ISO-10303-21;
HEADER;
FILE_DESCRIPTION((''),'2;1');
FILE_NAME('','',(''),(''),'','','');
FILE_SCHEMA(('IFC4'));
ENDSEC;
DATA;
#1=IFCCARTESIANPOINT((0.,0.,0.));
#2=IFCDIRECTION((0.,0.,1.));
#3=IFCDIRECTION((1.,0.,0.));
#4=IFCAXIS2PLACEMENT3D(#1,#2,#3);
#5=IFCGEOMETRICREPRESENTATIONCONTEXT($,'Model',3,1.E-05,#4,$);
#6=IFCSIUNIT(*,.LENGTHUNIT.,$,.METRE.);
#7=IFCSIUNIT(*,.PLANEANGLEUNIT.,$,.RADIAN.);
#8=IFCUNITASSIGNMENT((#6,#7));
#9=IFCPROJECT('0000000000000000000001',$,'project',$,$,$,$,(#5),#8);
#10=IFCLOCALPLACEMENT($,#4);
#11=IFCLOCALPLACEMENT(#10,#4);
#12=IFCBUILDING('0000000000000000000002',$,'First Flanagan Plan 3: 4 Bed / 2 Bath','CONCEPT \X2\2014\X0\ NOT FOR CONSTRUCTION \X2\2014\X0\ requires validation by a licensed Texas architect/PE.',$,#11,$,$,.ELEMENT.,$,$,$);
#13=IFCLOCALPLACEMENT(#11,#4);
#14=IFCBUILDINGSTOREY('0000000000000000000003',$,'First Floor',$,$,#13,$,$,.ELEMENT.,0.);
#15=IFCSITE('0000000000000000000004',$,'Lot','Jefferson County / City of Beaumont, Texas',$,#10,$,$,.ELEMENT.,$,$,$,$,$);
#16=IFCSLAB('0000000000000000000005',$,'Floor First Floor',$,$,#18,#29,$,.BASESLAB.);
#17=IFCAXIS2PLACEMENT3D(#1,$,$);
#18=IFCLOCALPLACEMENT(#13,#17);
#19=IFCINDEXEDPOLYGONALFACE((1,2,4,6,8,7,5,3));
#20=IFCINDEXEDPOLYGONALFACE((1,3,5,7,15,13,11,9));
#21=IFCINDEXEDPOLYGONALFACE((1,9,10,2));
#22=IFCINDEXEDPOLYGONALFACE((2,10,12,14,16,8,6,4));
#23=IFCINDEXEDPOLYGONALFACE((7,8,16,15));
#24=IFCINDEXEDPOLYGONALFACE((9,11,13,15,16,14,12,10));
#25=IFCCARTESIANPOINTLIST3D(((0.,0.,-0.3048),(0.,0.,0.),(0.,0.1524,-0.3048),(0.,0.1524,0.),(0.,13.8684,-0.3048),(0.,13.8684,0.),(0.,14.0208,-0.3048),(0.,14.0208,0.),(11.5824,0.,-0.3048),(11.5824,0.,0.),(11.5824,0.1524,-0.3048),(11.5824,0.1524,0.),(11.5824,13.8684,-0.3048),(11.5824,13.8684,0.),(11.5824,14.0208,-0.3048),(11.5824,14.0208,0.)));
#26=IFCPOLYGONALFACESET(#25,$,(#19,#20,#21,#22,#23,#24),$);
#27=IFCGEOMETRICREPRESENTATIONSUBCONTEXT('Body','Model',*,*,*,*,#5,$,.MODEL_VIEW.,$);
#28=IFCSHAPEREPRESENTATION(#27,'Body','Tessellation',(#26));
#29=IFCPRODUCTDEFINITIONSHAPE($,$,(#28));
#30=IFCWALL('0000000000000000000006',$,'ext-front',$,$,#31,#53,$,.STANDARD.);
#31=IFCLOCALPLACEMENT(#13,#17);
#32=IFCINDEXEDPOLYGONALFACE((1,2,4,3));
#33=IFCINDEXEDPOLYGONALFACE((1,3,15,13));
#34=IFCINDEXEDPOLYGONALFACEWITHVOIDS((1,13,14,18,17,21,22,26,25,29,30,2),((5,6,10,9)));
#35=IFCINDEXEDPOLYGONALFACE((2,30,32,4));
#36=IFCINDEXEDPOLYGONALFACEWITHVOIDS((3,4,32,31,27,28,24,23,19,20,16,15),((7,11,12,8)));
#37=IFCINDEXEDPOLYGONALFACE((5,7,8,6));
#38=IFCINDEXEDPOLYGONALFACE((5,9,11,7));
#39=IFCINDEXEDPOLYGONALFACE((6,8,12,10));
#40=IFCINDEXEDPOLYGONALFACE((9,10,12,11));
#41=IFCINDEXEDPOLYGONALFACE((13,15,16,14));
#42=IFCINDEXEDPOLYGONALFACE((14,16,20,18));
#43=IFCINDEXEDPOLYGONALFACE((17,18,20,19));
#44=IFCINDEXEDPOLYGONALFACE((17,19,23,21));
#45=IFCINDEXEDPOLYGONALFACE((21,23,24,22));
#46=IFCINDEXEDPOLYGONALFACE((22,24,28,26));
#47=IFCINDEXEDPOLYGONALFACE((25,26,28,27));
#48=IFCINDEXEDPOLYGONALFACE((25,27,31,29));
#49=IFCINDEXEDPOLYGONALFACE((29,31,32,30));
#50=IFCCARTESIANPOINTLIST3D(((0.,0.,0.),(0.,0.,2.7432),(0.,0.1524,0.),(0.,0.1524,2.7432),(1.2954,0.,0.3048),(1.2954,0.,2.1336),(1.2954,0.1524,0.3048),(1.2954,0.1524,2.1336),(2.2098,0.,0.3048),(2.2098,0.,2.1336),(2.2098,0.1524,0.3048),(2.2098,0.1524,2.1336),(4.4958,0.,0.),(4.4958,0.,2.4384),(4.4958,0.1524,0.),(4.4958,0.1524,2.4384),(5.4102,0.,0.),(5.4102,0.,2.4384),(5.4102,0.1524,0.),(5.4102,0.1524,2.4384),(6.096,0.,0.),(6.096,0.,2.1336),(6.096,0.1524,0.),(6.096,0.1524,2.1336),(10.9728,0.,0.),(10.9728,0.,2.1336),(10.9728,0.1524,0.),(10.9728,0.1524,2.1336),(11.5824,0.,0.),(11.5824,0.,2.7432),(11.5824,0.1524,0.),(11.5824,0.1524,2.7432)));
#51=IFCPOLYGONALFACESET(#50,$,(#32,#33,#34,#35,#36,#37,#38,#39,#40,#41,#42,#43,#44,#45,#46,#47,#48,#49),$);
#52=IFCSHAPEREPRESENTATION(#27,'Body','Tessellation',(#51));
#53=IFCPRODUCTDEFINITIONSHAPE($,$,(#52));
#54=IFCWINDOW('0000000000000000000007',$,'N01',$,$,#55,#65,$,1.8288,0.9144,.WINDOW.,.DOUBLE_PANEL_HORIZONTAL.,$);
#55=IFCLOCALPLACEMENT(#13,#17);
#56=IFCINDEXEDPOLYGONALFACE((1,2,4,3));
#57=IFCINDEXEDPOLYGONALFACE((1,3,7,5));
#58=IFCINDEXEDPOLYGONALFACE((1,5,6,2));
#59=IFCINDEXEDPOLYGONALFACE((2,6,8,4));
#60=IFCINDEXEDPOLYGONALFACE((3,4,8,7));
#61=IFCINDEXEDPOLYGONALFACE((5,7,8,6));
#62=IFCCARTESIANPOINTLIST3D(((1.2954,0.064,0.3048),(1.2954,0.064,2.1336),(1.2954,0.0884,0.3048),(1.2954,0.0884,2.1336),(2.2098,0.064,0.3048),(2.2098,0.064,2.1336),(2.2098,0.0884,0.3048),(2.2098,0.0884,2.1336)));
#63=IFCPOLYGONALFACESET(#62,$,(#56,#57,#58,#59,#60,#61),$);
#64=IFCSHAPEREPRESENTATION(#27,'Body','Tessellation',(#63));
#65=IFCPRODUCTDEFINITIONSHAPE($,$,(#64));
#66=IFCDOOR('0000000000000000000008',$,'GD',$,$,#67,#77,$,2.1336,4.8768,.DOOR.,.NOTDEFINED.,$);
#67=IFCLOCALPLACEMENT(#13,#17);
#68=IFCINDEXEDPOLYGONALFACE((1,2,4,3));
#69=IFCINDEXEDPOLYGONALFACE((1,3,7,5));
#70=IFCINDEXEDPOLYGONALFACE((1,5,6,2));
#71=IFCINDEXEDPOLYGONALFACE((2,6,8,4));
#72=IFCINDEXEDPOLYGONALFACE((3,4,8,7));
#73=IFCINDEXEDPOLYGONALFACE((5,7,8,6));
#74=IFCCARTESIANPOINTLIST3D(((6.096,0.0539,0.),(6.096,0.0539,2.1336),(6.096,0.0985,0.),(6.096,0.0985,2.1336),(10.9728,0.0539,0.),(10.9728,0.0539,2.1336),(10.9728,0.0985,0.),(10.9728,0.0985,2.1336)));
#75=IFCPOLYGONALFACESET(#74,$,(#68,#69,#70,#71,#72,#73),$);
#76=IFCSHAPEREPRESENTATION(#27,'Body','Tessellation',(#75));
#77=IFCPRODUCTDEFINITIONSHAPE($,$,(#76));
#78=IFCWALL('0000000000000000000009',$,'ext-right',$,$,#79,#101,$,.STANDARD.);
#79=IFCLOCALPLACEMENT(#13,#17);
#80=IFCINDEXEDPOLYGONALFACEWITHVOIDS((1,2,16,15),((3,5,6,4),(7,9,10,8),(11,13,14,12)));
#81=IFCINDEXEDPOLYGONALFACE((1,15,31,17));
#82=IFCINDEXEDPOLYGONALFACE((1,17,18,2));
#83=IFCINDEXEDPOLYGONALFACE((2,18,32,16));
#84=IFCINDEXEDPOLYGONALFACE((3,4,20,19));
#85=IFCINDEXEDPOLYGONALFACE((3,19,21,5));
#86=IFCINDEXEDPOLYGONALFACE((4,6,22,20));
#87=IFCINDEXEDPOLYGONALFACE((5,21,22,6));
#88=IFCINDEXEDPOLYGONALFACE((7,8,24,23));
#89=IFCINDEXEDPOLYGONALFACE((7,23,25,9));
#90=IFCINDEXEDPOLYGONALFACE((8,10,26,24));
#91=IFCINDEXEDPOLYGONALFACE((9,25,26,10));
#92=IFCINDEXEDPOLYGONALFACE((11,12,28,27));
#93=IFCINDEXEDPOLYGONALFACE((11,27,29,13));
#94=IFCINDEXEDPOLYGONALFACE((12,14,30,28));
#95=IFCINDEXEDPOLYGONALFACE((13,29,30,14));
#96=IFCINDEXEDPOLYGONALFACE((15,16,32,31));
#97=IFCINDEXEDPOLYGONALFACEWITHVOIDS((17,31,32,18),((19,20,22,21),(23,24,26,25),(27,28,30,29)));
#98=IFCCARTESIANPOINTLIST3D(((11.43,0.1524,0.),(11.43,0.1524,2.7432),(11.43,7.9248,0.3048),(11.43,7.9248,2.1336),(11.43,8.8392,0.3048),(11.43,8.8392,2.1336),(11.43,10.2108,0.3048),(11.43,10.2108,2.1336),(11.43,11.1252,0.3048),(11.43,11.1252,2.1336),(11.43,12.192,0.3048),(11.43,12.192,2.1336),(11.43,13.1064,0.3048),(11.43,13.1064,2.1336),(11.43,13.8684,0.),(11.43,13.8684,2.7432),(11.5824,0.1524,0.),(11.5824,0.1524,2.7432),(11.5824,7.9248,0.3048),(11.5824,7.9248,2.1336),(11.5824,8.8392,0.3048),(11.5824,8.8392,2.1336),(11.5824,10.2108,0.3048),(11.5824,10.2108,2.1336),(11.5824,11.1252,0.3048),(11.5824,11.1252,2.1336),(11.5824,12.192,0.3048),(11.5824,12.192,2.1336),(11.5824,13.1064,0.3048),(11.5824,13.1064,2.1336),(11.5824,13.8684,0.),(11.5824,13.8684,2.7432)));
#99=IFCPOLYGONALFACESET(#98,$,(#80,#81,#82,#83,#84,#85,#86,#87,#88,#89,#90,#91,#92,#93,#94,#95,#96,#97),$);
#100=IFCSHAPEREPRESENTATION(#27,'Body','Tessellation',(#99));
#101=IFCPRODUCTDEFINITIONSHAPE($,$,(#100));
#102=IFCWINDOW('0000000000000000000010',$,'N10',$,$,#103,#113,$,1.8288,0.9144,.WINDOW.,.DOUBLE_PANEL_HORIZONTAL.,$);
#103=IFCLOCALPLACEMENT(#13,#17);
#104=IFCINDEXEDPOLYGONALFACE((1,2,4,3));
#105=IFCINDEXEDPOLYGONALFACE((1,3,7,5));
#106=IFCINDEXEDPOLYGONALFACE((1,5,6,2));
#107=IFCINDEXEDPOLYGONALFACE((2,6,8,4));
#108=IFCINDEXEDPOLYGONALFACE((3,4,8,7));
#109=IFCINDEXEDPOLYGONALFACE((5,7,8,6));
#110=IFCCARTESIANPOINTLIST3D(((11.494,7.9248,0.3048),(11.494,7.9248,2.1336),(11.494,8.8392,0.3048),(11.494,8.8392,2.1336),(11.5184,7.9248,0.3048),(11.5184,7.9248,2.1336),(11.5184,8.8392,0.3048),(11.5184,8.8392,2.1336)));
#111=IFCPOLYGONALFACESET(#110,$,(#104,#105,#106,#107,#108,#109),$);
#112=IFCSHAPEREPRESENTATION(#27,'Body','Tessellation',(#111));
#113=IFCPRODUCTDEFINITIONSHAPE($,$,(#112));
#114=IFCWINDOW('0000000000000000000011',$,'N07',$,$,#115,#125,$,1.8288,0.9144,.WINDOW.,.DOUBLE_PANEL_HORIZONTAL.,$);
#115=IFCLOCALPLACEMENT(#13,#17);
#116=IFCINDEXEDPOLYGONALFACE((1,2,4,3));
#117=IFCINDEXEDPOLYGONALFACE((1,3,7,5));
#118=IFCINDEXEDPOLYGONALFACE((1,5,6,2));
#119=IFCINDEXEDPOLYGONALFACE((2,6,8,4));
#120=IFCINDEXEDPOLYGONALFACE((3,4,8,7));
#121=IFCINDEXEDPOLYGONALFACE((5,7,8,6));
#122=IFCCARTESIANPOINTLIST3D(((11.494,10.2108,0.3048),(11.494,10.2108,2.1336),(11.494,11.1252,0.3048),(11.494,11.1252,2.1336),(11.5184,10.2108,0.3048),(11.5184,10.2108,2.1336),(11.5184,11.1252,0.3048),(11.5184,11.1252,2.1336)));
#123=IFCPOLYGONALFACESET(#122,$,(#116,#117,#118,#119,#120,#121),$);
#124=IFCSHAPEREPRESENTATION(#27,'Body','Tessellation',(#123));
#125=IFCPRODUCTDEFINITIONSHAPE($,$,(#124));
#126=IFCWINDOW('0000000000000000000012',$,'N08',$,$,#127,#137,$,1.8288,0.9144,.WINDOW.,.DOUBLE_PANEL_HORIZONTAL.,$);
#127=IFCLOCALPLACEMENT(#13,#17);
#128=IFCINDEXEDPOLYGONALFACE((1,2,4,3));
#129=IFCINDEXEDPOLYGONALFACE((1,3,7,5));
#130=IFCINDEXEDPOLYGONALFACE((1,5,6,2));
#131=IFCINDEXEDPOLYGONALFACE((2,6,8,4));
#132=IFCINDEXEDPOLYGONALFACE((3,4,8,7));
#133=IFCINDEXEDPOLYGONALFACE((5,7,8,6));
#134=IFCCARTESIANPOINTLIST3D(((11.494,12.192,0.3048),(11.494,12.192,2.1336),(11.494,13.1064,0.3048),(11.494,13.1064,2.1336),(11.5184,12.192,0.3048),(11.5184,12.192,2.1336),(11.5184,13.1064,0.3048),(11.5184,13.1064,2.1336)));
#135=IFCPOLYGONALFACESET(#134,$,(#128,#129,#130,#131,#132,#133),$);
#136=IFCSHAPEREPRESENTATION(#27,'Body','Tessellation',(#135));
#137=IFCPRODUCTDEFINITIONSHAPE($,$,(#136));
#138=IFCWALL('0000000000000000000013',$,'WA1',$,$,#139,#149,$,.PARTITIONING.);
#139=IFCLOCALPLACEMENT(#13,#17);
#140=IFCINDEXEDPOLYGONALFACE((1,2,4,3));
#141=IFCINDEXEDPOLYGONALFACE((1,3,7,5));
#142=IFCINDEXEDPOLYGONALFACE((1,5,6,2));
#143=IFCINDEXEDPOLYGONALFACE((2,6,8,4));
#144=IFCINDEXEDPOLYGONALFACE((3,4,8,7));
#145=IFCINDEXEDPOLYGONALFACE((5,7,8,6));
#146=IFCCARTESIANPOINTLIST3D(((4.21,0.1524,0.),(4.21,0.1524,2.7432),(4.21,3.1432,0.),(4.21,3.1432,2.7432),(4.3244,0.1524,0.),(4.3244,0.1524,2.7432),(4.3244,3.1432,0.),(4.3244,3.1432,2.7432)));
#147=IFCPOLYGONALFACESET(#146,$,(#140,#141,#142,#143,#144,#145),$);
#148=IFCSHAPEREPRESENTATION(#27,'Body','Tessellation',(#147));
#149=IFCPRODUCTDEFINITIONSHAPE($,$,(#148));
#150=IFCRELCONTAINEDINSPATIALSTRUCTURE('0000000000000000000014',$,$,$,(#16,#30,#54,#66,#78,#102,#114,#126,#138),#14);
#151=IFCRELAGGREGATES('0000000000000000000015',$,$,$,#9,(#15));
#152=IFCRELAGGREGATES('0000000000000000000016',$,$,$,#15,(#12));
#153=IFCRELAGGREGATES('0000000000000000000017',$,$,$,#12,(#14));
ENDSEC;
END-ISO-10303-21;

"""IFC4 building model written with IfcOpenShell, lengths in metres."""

from ifc_helpers import new_model, si_unit, frame, frame_2d, origin_with_axes, place, context, subcontext, project, spatial, polyline, rectangle, outline, extrude, element, fill, save


model = new_model("IFC4")

# Units and contexts
model_context = context("Model", 3, precision=1e-05, world=origin_with_axes())
body_context = subcontext(model_context, "Body", "Model", "MODEL_VIEW")
ifc_project = project(units=[si_unit("LENGTHUNIT", "METRE"), si_unit("PLANEANGLEUNIT", "RADIAN")], contexts=[model_context])

# Site, building, storey
site_placement = place(None, origin_with_axes())
site = spatial("IfcSite", under=ifc_project, at=site_placement, Name="Lot", Description="Jefferson County / City of Beaumont, Texas", CompositionType="ELEMENT")
building_placement = place(site_placement, origin_with_axes())
building = spatial("IfcBuilding", under=site, at=building_placement, Name="First Flanagan Plan 3: 4 Bed / 2 Bath", Description="CONCEPT — NOT FOR CONSTRUCTION — requires validation by a licensed Texas architect/PE.", CompositionType="ELEMENT")
storey_placement = place(building_placement, origin_with_axes())
storey = spatial("IfcBuildingStorey", under=building, at=storey_placement, Name="First Floor", CompositionType="ELEMENT", Elevation=0.0)

# Slab
slab_placement = place(storey_placement, frame((0.0, 0.0, -0.3048), z_axis=(0.0, 0.0, 1.0), x_axis=(1.0, 0.0, 0.0)))
element("IfcSlab", 1, at=slab_placement, inside=storey, Name="Floor First Floor", PredefinedType="BASESLAB", context=body_context, shape_type="SweptSolid", body=[
    extrude(outline(polyline([(11.5824, 0.1524), (11.5824, 0.0), (0.0, 0.0), (0.0, 0.1524), (0.0, 13.8684), (0.0, 14.0208), (11.5824, 14.0208), (11.5824, 13.8684), (11.5824, 0.1524)])), origin_with_axes(), (0.0, 0.0, 1.0), 0.3048),
])

# Wall, openings, window, door
wall_1_placement = place(storey_placement, frame((0.0, 0.0762, 0.0), z_axis=(0.0, 0.0, 1.0), x_axis=(1.0, 0.0, 0.0)))
wall_1 = element("IfcWall", 2, at=wall_1_placement, inside=storey, Name="ext-front", PredefinedType="STANDARD", context=body_context, shape_type="SweptSolid", body=[
    extrude(rectangle(XDim=11.5824, YDim=0.1524, at=frame_2d((5.7912, 0.0), x_axis=(1.0, 0.0))), origin_with_axes(), (0.0, 0.0, 1.0), 2.7432),
])
opening_1_placement = place(wall_1_placement, frame((1.2954, 0.0, 0.3048), z_axis=(0.0, 0.0, 1.0), x_axis=(1.0, 0.0, 0.0)))
opening_1 = element("IfcOpeningElement", 3, at=opening_1_placement, cuts=wall_1, PredefinedType="OPENING", context=body_context, shape_type="SweptSolid", body=[
    extrude(rectangle(XDim=0.9144, YDim=0.1829, at=frame_2d((0.4572, 0.0), x_axis=(1.0, 0.0))), origin_with_axes(), (0.0, 0.0, 1.0), 1.8288),
])
opening_2_placement = place(wall_1_placement, frame((4.4958, 0.0, 0.0), z_axis=(0.0, 0.0, 1.0), x_axis=(1.0, 0.0, 0.0)))
element("IfcOpeningElement", 4, at=opening_2_placement, cuts=wall_1, PredefinedType="OPENING", context=body_context, shape_type="SweptSolid", body=[
    extrude(rectangle(XDim=0.9144, YDim=0.1829, at=frame_2d((0.4572, 0.0), x_axis=(1.0, 0.0))), origin_with_axes(), (0.0, 0.0, 1.0), 2.4384),
])
opening_3_placement = place(wall_1_placement, frame((6.096, 0.0, 0.0), z_axis=(0.0, 0.0, 1.0), x_axis=(1.0, 0.0, 0.0)))
opening_3 = element("IfcOpeningElement", 5, at=opening_3_placement, cuts=wall_1, PredefinedType="OPENING", context=body_context, shape_type="SweptSolid", body=[
    extrude(rectangle(XDim=4.8768, YDim=0.1829, at=frame_2d((2.4384, 0.0), x_axis=(1.0, 0.0))), origin_with_axes(), (0.0, 0.0, 1.0), 2.1336),
])
window_1_placement = place(opening_1_placement, origin_with_axes())
window_1 = element("IfcWindow", 6, at=window_1_placement, inside=storey, Name="N01", OverallHeight=1.8288, OverallWidth=0.9144, PartitioningType="DOUBLE_PANEL_HORIZONTAL", PredefinedType="WINDOW", context=body_context, shape_type="SweptSolid", body=[
    extrude(rectangle(XDim=0.9144, YDim=0.0244, at=frame_2d((0.4572, 0.0), x_axis=(1.0, 0.0))), origin_with_axes(), (0.0, 0.0, 1.0), 1.8288),
])
fill(opening_1, window_1)
door_1_placement = place(opening_3_placement, origin_with_axes())
door_1 = element("IfcDoor", 7, at=door_1_placement, inside=storey, Name="GD", OperationType="NOTDEFINED", OverallHeight=2.1336, OverallWidth=4.8768, PredefinedType="DOOR", context=body_context, shape_type="SweptSolid", body=[
    extrude(rectangle(XDim=4.8768, YDim=0.0445, at=frame_2d((2.4384, 0.0), x_axis=(1.0, 0.0))), origin_with_axes(), (0.0, 0.0, 1.0), 2.1336),
])
fill(opening_3, door_1)

# Wall, openings, windows
wall_2_placement = place(storey_placement, frame((11.5062, 0.1524, 0.0), z_axis=(0.0, 0.0, 1.0), x_axis=(0.0, 1.0, 0.0)))
wall_2 = element("IfcWall", 8, at=wall_2_placement, inside=storey, Name="ext-right", PredefinedType="STANDARD", context=body_context, shape_type="SweptSolid", body=[
    extrude(rectangle(XDim=13.716, YDim=0.1524, at=frame_2d((6.858, 0.0), x_axis=(1.0, 0.0))), origin_with_axes(), (0.0, 0.0, 1.0), 2.7432),
])
opening_4_placement = place(wall_2_placement, frame((7.7724, 0.0, 0.3048), z_axis=(0.0, 0.0, 1.0), x_axis=(1.0, 0.0, 0.0)))
opening_4 = element("IfcOpeningElement", 9, at=opening_4_placement, cuts=wall_2, PredefinedType="OPENING", context=body_context, shape_type="SweptSolid", body=[
    extrude(rectangle(XDim=0.9144, YDim=0.1829, at=frame_2d((0.4572, 0.0), x_axis=(1.0, 0.0))), origin_with_axes(), (0.0, 0.0, 1.0), 1.8288),
])
opening_5_placement = place(wall_2_placement, frame((10.0584, 0.0, 0.3048), z_axis=(0.0, 0.0, 1.0), x_axis=(1.0, 0.0, 0.0)))
opening_5 = element("IfcOpeningElement", 10, at=opening_5_placement, cuts=wall_2, PredefinedType="OPENING", context=body_context, shape_type="SweptSolid", body=[
    extrude(rectangle(XDim=0.9144, YDim=0.1829, at=frame_2d((0.4572, 0.0), x_axis=(1.0, 0.0))), origin_with_axes(), (0.0, 0.0, 1.0), 1.8288),
])
opening_6_placement = place(wall_2_placement, frame((12.0396, 0.0, 0.3048), z_axis=(0.0, 0.0, 1.0), x_axis=(1.0, 0.0, 0.0)))
opening_6 = element("IfcOpeningElement", 11, at=opening_6_placement, cuts=wall_2, PredefinedType="OPENING", context=body_context, shape_type="SweptSolid", body=[
    extrude(rectangle(XDim=0.9144, YDim=0.1829, at=frame_2d((0.4572, 0.0), x_axis=(1.0, 0.0))), origin_with_axes(), (0.0, 0.0, 1.0), 1.8288),
])
window_2_placement = place(opening_4_placement, origin_with_axes())
window_2 = element("IfcWindow", 12, at=window_2_placement, inside=storey, Name="N10", OverallHeight=1.8288, OverallWidth=0.9144, PartitioningType="DOUBLE_PANEL_HORIZONTAL", PredefinedType="WINDOW", context=body_context, shape_type="SweptSolid", body=[
    extrude(rectangle(XDim=0.9144, YDim=0.0244, at=frame_2d((0.4572, 0.0), x_axis=(1.0, 0.0))), origin_with_axes(), (0.0, 0.0, 1.0), 1.8288),
])
fill(opening_4, window_2)
window_3_placement = place(opening_5_placement, origin_with_axes())
window_3 = element("IfcWindow", 13, at=window_3_placement, inside=storey, Name="N07", OverallHeight=1.8288, OverallWidth=0.9144, PartitioningType="DOUBLE_PANEL_HORIZONTAL", PredefinedType="WINDOW", context=body_context, shape_type="SweptSolid", body=[
    extrude(rectangle(XDim=0.9144, YDim=0.0244, at=frame_2d((0.4572, 0.0), x_axis=(1.0, 0.0))), origin_with_axes(), (0.0, 0.0, 1.0), 1.8288),
])
fill(opening_5, window_3)
window_4_placement = place(opening_6_placement, origin_with_axes())
window_4 = element("IfcWindow", 14, at=window_4_placement, inside=storey, Name="N08", OverallHeight=1.8288, OverallWidth=0.9144, PartitioningType="DOUBLE_PANEL_HORIZONTAL", PredefinedType="WINDOW", context=body_context, shape_type="SweptSolid", body=[
    extrude(rectangle(XDim=0.9144, YDim=0.0244, at=frame_2d((0.4572, 0.0), x_axis=(1.0, 0.0))), origin_with_axes(), (0.0, 0.0, 1.0), 1.8288),
])
fill(opening_6, window_4)

# Wall
wall_3_placement = place(storey_placement, frame((4.2672, 0.1524, 0.0), z_axis=(0.0, 0.0, 1.0), x_axis=(0.0, 1.0, 0.0)))
element("IfcWall", 15, at=wall_3_placement, inside=storey, Name="WA1", PredefinedType="PARTITIONING", context=body_context, shape_type="SweptSolid", body=[
    extrude(rectangle(XDim=2.9909, YDim=0.1143, at=frame_2d((1.4954, 0.0), x_axis=(1.0, 0.0))), origin_with_axes(), (0.0, 0.0, 1.0), 2.7432),
])

save(model, "model.ifc")
